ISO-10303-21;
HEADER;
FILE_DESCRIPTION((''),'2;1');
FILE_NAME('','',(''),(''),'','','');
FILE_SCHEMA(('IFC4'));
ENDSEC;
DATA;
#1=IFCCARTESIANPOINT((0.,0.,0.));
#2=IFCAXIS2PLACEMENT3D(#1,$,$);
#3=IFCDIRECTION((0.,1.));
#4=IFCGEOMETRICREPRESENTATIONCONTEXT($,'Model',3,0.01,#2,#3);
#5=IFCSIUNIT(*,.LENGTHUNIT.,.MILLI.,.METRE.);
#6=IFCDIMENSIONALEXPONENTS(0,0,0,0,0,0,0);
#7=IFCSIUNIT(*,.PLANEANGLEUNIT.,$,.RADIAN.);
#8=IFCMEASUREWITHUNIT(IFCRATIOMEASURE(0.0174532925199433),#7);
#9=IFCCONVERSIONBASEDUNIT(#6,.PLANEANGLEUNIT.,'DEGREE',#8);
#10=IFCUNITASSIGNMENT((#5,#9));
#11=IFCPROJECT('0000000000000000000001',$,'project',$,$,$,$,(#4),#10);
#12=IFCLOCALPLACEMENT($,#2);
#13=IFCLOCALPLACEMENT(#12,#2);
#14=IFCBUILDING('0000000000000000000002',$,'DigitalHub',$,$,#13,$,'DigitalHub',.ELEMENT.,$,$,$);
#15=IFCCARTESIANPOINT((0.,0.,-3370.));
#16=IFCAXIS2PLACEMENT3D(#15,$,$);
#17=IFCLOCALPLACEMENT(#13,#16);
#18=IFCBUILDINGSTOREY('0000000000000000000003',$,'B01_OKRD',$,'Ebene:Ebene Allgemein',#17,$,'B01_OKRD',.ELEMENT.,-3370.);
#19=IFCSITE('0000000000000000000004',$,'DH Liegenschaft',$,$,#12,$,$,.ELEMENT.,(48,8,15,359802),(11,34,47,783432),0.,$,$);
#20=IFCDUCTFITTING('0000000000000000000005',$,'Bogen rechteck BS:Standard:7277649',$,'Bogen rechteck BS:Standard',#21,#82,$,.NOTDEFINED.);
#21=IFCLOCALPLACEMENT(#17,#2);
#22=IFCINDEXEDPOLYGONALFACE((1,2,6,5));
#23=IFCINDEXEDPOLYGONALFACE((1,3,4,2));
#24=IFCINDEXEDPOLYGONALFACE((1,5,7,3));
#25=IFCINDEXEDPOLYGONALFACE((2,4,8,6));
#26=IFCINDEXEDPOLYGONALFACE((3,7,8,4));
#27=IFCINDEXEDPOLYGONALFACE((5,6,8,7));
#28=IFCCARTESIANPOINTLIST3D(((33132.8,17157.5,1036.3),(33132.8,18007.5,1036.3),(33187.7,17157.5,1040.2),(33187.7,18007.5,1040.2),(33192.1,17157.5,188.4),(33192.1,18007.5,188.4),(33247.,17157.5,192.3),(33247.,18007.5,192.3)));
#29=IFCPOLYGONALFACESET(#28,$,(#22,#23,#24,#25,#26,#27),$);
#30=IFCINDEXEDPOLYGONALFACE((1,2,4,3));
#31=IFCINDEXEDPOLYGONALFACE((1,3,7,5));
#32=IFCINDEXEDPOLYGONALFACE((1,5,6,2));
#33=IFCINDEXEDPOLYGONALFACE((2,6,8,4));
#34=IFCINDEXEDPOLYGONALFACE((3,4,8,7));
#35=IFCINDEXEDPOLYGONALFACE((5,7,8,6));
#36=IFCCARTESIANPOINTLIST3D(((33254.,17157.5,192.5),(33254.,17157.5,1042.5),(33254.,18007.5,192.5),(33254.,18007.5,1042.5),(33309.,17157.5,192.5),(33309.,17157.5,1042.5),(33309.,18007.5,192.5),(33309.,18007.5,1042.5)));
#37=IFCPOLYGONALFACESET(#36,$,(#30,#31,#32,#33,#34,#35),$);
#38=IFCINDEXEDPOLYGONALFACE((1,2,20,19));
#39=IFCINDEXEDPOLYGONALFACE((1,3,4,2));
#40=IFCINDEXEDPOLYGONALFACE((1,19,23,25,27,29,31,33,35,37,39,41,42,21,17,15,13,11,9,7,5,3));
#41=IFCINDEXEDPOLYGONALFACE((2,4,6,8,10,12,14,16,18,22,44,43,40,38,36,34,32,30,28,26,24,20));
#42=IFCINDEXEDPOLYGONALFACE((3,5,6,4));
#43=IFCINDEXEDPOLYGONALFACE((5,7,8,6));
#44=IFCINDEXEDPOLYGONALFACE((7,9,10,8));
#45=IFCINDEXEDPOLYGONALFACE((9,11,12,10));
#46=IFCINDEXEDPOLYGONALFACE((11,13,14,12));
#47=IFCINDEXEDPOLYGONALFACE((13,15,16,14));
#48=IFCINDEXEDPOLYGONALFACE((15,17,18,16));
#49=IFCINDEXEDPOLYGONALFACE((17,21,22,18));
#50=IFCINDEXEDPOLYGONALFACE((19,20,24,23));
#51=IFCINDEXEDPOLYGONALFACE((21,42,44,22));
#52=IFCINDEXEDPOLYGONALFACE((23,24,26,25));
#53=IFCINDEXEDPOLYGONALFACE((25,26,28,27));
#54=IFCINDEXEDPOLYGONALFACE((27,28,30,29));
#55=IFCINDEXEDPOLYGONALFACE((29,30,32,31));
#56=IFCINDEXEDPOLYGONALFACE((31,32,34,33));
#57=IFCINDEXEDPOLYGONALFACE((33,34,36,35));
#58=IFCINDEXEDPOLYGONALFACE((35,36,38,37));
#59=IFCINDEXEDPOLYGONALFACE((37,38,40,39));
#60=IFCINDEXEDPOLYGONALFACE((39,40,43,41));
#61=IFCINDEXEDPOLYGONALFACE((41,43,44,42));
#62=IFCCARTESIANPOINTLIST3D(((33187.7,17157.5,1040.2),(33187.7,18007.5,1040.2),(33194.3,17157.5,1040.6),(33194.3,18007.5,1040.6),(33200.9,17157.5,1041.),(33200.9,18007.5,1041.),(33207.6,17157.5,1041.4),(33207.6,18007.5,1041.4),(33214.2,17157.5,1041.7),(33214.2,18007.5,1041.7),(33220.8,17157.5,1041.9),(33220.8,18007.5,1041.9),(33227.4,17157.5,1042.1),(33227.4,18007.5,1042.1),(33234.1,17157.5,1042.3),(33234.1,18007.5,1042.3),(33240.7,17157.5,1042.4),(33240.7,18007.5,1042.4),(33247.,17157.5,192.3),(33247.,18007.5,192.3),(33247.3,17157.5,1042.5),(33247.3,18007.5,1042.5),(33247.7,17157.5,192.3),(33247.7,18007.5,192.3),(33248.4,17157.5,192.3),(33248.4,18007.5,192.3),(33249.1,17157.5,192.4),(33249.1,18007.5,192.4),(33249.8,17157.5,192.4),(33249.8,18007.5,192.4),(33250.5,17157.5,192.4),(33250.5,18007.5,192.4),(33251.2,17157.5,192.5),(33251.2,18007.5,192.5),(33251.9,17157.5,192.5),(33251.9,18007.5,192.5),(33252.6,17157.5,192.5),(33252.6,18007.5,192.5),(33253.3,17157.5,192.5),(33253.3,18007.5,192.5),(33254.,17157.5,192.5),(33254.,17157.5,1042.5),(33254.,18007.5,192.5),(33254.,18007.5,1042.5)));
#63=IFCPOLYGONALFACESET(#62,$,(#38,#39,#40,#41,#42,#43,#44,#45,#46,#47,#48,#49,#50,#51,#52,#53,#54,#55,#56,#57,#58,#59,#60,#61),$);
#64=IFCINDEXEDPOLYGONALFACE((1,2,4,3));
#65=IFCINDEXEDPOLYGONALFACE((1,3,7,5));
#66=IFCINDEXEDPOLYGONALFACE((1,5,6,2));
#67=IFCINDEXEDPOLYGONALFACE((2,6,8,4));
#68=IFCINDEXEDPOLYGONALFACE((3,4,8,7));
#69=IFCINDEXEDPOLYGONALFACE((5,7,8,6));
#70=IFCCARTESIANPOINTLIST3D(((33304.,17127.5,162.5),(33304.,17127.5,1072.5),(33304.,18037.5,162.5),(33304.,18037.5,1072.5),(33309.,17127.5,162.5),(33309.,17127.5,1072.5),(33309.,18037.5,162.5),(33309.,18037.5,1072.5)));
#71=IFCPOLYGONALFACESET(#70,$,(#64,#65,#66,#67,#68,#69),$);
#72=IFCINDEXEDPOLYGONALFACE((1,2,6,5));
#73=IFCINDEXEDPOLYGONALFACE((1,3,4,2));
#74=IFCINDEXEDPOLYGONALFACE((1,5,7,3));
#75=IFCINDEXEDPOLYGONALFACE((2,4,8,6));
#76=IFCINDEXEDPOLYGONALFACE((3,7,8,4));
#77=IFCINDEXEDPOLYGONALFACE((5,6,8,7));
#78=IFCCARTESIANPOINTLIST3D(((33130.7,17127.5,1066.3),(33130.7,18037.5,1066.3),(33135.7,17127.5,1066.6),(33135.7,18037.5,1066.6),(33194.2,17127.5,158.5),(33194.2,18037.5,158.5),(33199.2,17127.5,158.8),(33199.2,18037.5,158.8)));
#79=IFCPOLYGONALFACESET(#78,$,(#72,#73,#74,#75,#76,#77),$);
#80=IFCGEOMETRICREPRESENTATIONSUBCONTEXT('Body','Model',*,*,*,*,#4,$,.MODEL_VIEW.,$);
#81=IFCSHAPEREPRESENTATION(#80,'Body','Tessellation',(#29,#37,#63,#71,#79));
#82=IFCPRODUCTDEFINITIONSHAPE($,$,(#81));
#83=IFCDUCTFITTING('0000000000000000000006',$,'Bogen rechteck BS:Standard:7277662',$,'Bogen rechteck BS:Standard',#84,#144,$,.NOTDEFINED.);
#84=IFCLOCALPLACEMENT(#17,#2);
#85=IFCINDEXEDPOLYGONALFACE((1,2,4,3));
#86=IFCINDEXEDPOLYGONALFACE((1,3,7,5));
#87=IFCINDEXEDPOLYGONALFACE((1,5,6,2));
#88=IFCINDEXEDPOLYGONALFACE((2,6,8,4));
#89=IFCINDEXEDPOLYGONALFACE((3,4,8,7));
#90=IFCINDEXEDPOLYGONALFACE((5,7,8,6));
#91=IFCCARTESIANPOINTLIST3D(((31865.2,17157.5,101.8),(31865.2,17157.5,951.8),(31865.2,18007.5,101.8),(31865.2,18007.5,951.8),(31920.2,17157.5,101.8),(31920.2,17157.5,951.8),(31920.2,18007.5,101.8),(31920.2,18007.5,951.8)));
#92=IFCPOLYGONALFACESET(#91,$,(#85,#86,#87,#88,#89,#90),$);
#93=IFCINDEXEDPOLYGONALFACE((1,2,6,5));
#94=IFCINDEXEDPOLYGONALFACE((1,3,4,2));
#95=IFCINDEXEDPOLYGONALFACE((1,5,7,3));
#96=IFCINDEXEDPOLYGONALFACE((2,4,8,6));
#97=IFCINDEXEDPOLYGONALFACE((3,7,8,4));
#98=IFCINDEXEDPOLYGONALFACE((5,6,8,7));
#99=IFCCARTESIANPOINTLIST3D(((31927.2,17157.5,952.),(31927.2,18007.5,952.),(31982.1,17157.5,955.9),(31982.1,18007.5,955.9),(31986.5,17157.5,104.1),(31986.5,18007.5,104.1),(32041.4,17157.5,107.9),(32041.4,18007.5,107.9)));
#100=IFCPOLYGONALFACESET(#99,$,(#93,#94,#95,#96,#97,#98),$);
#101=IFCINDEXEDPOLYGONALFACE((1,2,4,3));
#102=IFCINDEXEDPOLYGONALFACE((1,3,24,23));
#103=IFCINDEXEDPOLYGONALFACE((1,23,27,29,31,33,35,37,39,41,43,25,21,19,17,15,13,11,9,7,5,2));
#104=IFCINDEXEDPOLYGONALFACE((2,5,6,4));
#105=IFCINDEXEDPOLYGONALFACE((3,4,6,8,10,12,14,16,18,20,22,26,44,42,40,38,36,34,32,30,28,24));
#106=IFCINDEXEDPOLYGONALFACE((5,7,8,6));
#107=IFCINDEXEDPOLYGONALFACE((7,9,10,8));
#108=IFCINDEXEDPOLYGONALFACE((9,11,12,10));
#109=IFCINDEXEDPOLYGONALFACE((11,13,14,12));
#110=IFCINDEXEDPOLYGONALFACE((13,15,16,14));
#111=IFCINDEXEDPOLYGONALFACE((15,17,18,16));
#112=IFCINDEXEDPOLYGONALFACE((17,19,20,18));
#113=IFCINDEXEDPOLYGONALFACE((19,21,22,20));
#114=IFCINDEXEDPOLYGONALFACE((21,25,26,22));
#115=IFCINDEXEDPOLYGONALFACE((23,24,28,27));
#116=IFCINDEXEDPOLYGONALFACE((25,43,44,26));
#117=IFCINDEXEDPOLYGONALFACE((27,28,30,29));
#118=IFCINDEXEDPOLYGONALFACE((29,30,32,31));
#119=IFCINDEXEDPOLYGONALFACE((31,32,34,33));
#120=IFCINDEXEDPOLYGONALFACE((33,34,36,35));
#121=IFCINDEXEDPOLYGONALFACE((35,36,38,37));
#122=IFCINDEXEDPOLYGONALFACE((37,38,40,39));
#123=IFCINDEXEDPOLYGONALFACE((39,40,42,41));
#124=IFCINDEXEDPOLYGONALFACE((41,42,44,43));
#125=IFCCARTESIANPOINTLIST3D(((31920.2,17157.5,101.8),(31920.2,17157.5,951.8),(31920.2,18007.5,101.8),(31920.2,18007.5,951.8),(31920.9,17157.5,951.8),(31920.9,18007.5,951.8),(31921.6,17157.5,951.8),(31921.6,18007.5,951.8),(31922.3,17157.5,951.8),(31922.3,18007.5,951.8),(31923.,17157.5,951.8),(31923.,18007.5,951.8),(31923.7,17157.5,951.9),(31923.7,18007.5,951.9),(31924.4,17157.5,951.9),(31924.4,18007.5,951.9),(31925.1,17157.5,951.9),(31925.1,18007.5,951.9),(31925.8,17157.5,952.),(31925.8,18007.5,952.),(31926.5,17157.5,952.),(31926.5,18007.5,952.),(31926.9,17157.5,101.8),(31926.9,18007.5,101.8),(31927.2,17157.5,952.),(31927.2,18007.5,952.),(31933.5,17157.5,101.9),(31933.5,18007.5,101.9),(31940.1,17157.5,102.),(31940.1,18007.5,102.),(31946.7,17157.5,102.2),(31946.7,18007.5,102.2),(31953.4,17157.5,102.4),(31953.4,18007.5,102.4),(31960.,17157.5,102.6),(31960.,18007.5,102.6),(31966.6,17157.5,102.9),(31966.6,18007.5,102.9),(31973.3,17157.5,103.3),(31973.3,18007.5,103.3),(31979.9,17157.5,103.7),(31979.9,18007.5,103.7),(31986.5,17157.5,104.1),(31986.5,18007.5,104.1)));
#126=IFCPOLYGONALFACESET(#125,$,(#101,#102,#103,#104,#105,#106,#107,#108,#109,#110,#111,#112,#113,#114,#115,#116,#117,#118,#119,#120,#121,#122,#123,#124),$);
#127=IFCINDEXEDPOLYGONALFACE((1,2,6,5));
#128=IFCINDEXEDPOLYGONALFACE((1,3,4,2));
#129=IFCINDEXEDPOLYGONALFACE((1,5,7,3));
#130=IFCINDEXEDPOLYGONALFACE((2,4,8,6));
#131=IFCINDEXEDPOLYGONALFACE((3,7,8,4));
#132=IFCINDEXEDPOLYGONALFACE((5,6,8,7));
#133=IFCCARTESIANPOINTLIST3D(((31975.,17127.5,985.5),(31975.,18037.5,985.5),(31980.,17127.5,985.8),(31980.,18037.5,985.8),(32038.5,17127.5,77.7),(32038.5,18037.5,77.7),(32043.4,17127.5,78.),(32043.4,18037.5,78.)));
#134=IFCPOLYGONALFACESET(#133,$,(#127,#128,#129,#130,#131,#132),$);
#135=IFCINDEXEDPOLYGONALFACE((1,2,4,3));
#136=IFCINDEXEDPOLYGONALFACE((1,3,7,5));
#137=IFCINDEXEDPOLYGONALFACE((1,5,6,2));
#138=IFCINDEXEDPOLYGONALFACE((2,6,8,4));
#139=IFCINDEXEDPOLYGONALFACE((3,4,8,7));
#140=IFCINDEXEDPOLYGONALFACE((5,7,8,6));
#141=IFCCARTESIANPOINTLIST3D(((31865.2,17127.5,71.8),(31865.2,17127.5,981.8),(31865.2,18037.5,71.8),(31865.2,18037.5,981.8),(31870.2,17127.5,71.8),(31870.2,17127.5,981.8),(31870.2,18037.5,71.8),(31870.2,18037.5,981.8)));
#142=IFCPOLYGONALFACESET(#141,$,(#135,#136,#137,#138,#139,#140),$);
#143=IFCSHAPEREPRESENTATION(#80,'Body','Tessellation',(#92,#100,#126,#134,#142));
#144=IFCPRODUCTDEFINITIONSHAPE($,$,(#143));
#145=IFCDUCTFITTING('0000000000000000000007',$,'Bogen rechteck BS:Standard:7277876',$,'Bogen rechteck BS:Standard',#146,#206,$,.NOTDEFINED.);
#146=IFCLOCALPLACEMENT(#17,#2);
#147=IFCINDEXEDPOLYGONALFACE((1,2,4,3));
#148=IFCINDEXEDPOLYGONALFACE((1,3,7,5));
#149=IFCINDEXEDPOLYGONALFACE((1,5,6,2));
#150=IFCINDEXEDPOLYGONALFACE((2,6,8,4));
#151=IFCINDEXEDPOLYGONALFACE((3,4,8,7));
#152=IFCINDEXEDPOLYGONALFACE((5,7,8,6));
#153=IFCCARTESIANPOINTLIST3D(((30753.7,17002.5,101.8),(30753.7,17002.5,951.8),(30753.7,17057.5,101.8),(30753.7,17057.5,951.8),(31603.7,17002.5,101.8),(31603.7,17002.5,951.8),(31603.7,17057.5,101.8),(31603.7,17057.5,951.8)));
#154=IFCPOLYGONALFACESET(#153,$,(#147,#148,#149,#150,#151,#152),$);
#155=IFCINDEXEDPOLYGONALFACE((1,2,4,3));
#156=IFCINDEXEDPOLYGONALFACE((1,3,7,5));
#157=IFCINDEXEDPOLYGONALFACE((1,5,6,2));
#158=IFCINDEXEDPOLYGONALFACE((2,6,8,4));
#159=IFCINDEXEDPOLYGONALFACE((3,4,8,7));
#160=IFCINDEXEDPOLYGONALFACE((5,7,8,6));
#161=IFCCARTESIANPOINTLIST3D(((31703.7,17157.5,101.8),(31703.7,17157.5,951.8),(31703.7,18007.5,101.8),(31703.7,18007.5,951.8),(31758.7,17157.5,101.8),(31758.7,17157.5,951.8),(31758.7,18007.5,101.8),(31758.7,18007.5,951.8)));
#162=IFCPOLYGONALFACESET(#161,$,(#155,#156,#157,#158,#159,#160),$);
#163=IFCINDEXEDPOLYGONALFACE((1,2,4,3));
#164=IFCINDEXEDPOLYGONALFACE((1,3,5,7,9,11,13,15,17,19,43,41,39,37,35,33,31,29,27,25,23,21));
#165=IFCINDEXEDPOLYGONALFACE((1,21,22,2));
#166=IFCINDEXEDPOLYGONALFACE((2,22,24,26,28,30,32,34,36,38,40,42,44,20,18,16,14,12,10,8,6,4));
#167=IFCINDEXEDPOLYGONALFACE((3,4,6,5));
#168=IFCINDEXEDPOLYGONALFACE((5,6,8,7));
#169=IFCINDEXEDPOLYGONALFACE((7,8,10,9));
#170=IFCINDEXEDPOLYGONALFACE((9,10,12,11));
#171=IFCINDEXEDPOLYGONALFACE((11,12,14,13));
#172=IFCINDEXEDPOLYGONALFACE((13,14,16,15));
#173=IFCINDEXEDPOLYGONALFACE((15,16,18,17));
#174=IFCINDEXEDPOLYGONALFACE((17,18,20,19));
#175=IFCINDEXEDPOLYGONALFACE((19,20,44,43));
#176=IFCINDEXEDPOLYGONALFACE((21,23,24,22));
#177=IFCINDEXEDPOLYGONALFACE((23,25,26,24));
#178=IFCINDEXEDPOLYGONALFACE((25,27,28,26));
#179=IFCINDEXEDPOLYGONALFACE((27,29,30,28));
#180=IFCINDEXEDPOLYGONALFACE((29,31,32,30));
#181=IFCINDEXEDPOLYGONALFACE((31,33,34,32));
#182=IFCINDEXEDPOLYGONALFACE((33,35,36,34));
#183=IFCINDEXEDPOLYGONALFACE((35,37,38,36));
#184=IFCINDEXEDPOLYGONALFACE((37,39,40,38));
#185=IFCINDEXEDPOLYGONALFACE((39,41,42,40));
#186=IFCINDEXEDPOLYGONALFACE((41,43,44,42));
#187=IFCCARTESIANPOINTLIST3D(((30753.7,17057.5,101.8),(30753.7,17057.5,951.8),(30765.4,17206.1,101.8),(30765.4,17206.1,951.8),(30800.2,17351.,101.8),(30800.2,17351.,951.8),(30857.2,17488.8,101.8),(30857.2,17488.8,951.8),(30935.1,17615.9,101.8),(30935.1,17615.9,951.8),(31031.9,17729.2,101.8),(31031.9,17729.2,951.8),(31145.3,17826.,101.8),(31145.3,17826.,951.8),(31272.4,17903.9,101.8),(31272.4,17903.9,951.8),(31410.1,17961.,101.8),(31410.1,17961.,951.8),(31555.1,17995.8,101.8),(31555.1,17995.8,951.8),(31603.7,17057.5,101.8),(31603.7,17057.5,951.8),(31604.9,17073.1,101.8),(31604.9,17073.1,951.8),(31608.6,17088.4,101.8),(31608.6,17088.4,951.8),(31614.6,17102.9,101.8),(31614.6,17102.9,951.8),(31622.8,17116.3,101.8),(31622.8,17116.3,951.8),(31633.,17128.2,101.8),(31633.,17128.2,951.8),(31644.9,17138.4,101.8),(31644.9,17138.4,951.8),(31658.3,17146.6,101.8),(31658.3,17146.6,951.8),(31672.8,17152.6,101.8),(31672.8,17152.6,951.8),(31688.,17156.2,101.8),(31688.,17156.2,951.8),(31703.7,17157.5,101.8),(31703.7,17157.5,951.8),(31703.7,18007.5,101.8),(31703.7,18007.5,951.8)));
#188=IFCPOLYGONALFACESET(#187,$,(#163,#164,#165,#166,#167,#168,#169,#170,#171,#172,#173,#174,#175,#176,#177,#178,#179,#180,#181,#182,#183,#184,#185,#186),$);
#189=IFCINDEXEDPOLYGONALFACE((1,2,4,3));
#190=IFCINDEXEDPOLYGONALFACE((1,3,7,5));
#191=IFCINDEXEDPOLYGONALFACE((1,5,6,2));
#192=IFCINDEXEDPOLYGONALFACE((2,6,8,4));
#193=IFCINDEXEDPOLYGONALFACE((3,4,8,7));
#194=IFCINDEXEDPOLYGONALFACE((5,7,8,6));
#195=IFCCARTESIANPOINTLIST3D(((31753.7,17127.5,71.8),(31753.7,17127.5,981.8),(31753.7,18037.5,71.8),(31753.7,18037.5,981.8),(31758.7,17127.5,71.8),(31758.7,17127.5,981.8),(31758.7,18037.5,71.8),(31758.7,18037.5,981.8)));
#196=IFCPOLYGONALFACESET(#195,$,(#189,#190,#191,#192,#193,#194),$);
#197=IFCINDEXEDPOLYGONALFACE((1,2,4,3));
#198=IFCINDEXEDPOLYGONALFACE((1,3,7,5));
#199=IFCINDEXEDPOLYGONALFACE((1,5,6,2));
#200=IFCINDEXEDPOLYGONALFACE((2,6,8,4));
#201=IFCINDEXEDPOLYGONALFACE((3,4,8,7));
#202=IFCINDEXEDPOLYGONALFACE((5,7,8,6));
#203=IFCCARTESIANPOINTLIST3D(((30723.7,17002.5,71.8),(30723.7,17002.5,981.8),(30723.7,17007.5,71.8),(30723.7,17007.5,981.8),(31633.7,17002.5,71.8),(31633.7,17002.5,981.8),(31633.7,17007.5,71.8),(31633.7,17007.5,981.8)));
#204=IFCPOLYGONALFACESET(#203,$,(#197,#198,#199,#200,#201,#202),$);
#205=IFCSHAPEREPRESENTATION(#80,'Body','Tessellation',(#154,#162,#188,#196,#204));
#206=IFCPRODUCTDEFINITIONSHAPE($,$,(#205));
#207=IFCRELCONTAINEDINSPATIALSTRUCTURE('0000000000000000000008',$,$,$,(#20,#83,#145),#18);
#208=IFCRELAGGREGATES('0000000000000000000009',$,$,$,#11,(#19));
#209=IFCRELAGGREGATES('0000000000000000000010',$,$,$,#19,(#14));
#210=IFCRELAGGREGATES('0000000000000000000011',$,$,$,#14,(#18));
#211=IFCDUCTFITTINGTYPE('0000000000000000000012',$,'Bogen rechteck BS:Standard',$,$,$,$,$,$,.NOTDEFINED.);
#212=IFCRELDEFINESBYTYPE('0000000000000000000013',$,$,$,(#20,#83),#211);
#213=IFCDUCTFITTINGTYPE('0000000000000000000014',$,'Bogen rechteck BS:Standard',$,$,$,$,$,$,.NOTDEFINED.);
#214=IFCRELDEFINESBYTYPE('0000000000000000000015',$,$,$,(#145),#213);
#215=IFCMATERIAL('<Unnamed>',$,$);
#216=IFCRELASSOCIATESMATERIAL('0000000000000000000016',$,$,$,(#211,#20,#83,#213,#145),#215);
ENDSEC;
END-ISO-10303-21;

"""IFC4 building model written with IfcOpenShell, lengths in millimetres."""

from ifc_helpers import new_model, entity, si_unit, converted_unit, direction, frame, origin, place, context, subcontext, project, spatial, indexed_curve, outline, extrude, source, transform, mapped, material, type_object, type_shapes, element, save


model = new_model("IFC4")

# Units and contexts
model_context = context("Model", 3, precision=0.01, world=origin(), true_north=direction((0.0, 1.0)))
body_context = subcontext(model_context, "Body", "Model", "MODEL_VIEW")
ifc_project = project(units=[si_unit("LENGTHUNIT", "METRE", prefix="MILLI"), converted_unit("PLANEANGLEUNIT", "DEGREE", entity("IfcRatioMeasure", 0.0174532925199433), si_unit("PLANEANGLEUNIT", "RADIAN"), dimensions=[0, 0, 0, 0, 0, 0, 0])], contexts=[model_context])

# Site, building, storey
site_placement = place(None, origin())
site = spatial("IfcSite", under=ifc_project, at=site_placement, Name="DH Liegenschaft", CompositionType="ELEMENT", RefLatitude=(48, 8, 15, 359802), RefLongitude=(11, 34, 47, 783432), RefElevation=0.0)
building_placement = place(site_placement, origin())
building = spatial("IfcBuilding", under=site, at=building_placement, Name="DigitalHub", LongName="DigitalHub", CompositionType="ELEMENT")
storey_placement = place(building_placement, frame((0.0, 0.0, -3370.0)))
storey = spatial("IfcBuildingStorey", under=building, at=storey_placement, Name="B01_OKRD", ObjectType="Ebene:Ebene Allgemein", LongName="B01_OKRD", CompositionType="ELEMENT", Elevation=-3370.0)

# Duct fittings
ifc_material_1 = material(Name="<Unnamed>")
duct_fitting_type_1 = type_object("IfcDuctFittingType", Name="Bogen rechteck BS:Standard", PredefinedType="NOTDEFINED", material=ifc_material_1)
shared_shape_1 = source(origin(), body_context, "Body", "SweptSolid", [
    extrude(outline(indexed_curve([(-27.5, -425.0), (27.5, -425.0), (27.5, 425.0), (-27.5, 425.0), (-27.5, -425.0)], self_intersect=False)), frame((45.7, 3.2, -425.0), z_axis=(0.0, 0.0, 1.0), x_axis=(0.997564, 0.069756, 0.0)), (0.0, 0.0, 1.0), 850.0),
    extrude(outline(indexed_curve([(-425.0, -27.5), (425.0, -27.5), (425.0, 27.5), (-425.0, 27.5), (-425.0, -27.5)], self_intersect=False)), frame((-45.8, 0.0, -425.0), z_axis=(0.0, 0.0, 1.0), x_axis=(0.0, -1.0, 0.0)), (0.0, 0.0, 1.0), 850.0),
    extrude(outline(indexed_curve([(-425.6, -18.3), (424.4, -18.3), (424.4, -17.6), (424.4, -16.9), (424.4, -16.2), (424.4, -15.5), (424.4, -14.8), (424.4, -14.1), (424.5, -13.4), (424.5, -12.7), (424.6, -12.0), (424.6, -11.3), (-423.3, 48.0), (-423.8, 41.3), (-424.2, 34.7), (-424.5, 28.1), (-424.8, 21.5), (-425.1, 14.8), (-425.3, 8.2), (-425.4, 1.6), (-425.5, -5.0), (-425.6, -11.7), (-425.6, -18.3)], self_intersect=False)), frame((0.0, 0.6, -425.0), z_axis=(0.0, 0.0, 1.0), x_axis=(-0.069756, 0.997564, 0.0)), (0.0, 0.0, 1.0), 850.0),
    extrude(outline(indexed_curve([(-2.5, -455.0), (2.5, -455.0), (2.5, 455.0), (-2.5, 455.0), (-2.5, -455.0)], self_intersect=False)), frame((-70.8, 0.0, -455.0)), (0.0, 0.0, 1.0), 910.0),
    extrude(outline(indexed_curve([(-2.5, -455.0), (2.5, -455.0), (2.5, 455.0), (-2.5, 455.0), (-2.5, -455.0)], self_intersect=False)), frame((70.7, 4.9, -455.0), z_axis=(0.0, 0.0, 1.0), x_axis=(0.997564, 0.069756, 0.0)), (0.0, 0.0, 1.0), 910.0),
])
type_shapes(duct_fitting_type_1, [shared_shape_1])
for number, where, z_axis, x_axis, name in (
    (1, (33235.6, 17582.5, 617.5), (0.0, -1.0, 0.0), (-1.0, 0.0, 0.0), "Bogen rechteck BS:Standard:7277649"),
    (2, (31938.6, 17582.5, 526.8), (0.0, 1.0, 0.0), (-0.997564, 0.0, -0.069756), "Bogen rechteck BS:Standard:7277662"),
):
    element("IfcDuctFitting", number, at=place(storey_placement, frame(where, z_axis=z_axis, x_axis=x_axis)), inside=storey, type_object=duct_fitting_type_1, material=ifc_material_1, Name=name, ObjectType="Bogen rechteck BS:Standard", PredefinedType="NOTDEFINED", context=body_context, shape_type="MappedRepresentation", body=[
        mapped(shared_shape_1, transform((0.0, 0.0, 0.0), scale=1.0)),
    ])
duct_fitting_type_2 = type_object("IfcDuctFittingType", Name="Bogen rechteck BS:Standard", PredefinedType="NOTDEFINED", material=ifc_material_1)
shared_shape_2 = source(origin(), body_context, "Body", "SweptSolid", [
    extrude(outline(indexed_curve([(-27.5, -425.0), (27.5, -425.0), (27.5, 425.0), (-27.5, 425.0), (-27.5, -425.0)], self_intersect=False)), frame((0.0, 552.5, -425.0), z_axis=(0.0, 0.0, 1.0), x_axis=(0.0, 1.0, 0.0)), (0.0, 0.0, 1.0), 850.0),
    extrude(outline(indexed_curve([(-425.0, -27.5), (425.0, -27.5), (425.0, 27.5), (-425.0, 27.5), (-425.0, -27.5)], self_intersect=False)), frame((-552.5, 0.0, -425.0), z_axis=(0.0, 0.0, 1.0), x_axis=(0.0, -1.0, 0.0)), (0.0, 0.0, 1.0), 850.0),
    extrude(outline(indexed_curve([(-687.5, -262.5), (162.5, -262.5), (163.7, -246.9), (167.4, -231.6), (173.4, -217.1), (181.6, -203.7), (191.8, -191.8), (203.7, -181.6), (217.1, -173.4), (231.6, -167.4), (246.9, -163.7), (262.5, -162.5), (262.5, 687.5), (113.9, 675.8), (-31.1, 641.0), (-168.8, 584.0), (-295.9, 506.1), (-409.3, 409.3), (-506.1, 295.9), (-584.0, 168.8), (-641.0, 31.1), (-675.8, -113.9), (-687.5, -262.5)], self_intersect=False)), frame((-262.5, 262.5, -425.0), z_axis=(0.0, 0.0, 1.0), x_axis=(-1.0, 0.0, 0.0)), (0.0, 0.0, 1.0), 850.0),
    extrude(outline(indexed_curve([(-2.5, -455.0), (2.5, -455.0), (2.5, 455.0), (-2.5, 455.0), (-2.5, -455.0)], self_intersect=False)), frame((-577.5, 0.0, -455.0)), (0.0, 0.0, 1.0), 910.0),
    extrude(outline(indexed_curve([(-2.5, -455.0), (2.5, -455.0), (2.5, 455.0), (-2.5, 455.0), (-2.5, -455.0)], self_intersect=False)), frame((0.0, 577.5, -455.0), z_axis=(0.0, 0.0, 1.0), x_axis=(0.0, 1.0, 0.0)), (0.0, 0.0, 1.0), 910.0),
])
type_shapes(duct_fitting_type_2, [shared_shape_2])
duct_fitting_1_placement = place(storey_placement, frame((31178.7, 17582.5, 526.8), z_axis=(0.0, 0.0, 1.0), x_axis=(-1.0, 0.0, 0.0)))
element("IfcDuctFitting", 3, at=duct_fitting_1_placement, inside=storey, type_object=duct_fitting_type_2, material=ifc_material_1, Name="Bogen rechteck BS:Standard:7277876", ObjectType="Bogen rechteck BS:Standard", PredefinedType="NOTDEFINED", context=body_context, shape_type="MappedRepresentation", body=[
    mapped(shared_shape_2, transform((0.0, 0.0, 0.0), scale=1.0)),
])

save(model, "model.ifc")
